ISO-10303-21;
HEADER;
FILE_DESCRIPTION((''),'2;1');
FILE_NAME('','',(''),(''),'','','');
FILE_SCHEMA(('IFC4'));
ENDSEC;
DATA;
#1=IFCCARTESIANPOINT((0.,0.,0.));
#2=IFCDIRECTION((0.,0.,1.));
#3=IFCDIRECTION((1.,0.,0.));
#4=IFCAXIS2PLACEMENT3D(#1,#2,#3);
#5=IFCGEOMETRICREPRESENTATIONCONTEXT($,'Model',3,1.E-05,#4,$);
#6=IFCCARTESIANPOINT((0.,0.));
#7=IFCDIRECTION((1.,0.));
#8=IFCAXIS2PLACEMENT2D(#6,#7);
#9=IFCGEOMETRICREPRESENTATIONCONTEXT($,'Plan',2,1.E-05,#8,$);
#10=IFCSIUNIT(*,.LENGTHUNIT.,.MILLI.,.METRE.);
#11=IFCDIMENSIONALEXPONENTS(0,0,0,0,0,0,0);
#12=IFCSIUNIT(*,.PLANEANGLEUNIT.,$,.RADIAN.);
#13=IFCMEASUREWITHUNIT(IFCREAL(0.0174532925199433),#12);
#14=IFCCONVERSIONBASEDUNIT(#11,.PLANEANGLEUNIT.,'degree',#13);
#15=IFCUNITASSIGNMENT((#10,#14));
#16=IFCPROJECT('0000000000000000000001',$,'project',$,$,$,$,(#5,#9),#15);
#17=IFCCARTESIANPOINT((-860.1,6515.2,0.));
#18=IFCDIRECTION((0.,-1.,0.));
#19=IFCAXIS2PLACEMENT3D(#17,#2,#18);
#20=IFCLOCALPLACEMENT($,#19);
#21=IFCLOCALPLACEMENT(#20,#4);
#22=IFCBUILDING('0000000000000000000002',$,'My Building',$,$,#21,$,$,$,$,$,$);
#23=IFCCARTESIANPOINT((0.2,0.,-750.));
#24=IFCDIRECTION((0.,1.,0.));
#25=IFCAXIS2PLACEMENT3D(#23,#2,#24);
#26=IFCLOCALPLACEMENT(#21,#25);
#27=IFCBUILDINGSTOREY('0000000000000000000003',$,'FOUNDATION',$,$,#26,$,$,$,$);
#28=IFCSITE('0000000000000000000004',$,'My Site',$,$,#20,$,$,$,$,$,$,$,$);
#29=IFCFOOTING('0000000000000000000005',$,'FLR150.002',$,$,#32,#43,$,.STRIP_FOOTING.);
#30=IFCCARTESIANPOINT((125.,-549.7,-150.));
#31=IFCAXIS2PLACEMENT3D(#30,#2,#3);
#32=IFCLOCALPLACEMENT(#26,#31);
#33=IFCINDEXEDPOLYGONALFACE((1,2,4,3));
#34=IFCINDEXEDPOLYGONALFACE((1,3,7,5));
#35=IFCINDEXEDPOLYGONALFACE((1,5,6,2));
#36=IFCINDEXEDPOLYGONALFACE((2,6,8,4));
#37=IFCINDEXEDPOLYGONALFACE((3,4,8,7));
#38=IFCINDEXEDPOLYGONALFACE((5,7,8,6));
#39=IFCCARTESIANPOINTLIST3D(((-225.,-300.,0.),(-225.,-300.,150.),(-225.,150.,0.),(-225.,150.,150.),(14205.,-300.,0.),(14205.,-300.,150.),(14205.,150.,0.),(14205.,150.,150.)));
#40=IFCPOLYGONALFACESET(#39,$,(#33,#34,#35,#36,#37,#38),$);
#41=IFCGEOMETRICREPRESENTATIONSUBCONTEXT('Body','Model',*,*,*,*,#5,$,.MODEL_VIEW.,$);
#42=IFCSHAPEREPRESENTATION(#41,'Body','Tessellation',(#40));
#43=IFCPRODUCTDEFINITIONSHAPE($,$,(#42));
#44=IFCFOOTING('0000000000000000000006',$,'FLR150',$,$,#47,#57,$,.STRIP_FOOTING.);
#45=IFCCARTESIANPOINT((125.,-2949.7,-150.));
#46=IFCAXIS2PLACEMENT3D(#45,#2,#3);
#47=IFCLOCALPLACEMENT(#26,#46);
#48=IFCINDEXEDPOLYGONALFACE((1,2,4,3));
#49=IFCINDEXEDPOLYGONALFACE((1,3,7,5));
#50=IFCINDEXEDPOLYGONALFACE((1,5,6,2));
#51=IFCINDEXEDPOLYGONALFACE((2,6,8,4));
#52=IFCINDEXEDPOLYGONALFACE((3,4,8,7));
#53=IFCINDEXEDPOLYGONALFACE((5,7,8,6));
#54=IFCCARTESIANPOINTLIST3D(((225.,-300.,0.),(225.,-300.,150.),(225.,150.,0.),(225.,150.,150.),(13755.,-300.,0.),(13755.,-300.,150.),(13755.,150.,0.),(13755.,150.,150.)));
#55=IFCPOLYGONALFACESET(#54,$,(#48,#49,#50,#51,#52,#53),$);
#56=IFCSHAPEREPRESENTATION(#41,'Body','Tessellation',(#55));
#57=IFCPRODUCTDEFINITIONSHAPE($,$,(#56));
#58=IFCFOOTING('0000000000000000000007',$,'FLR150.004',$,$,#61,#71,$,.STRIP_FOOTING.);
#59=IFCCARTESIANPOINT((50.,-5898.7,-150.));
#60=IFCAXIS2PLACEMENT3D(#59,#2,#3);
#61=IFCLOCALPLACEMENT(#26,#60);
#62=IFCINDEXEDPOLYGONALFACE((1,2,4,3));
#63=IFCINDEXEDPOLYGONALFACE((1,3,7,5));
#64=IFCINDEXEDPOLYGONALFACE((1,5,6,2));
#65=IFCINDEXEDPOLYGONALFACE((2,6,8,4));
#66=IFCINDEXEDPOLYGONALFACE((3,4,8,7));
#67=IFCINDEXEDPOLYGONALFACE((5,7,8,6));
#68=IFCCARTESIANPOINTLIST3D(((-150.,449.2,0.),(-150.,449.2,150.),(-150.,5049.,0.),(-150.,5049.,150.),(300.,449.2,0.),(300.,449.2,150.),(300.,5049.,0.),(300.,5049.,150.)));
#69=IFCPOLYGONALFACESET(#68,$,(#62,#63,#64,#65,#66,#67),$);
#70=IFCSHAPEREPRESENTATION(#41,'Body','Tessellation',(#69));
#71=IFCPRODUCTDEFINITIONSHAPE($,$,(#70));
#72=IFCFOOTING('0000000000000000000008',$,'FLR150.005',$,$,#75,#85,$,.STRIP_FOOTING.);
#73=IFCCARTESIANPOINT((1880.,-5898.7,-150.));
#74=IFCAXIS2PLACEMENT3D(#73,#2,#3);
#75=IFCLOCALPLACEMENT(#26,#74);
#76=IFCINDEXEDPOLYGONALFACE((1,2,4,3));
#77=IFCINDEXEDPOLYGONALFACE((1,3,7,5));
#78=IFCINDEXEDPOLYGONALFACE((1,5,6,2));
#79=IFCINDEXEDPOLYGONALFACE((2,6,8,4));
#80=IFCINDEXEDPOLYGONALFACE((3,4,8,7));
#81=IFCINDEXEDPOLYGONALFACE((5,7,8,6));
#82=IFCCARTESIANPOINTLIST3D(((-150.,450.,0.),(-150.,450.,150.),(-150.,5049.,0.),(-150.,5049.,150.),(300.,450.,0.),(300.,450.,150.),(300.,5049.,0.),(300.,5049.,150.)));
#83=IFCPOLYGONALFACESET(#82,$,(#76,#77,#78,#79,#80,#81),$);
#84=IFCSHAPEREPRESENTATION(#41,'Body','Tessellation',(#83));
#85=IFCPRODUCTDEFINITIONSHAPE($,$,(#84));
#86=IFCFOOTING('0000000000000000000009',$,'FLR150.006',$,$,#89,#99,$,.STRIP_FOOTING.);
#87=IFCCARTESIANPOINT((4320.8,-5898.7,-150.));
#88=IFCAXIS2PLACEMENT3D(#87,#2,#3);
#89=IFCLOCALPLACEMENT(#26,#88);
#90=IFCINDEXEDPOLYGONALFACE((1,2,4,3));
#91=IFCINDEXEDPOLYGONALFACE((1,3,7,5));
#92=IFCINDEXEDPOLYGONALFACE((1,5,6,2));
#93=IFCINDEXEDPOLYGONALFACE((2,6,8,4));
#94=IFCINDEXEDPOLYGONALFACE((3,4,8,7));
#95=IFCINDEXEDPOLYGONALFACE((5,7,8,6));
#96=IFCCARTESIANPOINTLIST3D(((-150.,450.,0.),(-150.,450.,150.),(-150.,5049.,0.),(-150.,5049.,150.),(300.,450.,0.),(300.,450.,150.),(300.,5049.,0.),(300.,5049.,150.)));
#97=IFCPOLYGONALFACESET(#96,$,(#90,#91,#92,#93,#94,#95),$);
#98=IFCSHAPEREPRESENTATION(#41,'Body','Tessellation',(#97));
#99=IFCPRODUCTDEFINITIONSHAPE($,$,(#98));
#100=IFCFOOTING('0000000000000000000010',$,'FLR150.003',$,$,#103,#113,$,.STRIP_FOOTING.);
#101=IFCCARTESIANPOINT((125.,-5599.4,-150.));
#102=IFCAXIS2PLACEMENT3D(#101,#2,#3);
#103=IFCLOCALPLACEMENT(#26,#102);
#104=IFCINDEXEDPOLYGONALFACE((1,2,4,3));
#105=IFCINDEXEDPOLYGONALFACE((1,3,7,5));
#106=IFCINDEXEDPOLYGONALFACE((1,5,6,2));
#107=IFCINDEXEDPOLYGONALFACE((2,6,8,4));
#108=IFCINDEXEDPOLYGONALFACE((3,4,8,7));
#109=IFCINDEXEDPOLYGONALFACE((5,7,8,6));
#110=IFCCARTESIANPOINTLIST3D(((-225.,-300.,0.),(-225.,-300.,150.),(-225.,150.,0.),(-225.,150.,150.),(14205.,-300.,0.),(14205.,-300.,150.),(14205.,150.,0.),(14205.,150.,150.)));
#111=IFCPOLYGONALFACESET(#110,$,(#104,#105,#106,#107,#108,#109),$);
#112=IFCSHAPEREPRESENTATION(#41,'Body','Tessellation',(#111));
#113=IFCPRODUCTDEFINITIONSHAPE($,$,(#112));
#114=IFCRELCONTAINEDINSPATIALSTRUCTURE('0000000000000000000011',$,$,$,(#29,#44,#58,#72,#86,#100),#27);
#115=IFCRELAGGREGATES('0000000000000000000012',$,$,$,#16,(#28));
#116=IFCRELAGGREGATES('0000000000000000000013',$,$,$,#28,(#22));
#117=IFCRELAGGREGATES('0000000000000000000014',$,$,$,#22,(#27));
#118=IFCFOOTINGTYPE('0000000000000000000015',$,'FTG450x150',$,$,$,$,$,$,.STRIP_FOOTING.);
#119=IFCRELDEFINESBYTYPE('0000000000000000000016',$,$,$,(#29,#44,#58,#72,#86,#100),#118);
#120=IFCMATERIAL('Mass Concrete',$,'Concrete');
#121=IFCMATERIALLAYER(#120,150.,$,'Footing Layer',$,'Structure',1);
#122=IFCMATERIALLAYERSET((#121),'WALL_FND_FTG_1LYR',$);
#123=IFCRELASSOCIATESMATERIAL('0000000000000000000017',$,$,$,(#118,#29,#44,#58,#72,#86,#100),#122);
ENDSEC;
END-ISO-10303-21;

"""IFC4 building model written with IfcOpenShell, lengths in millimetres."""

from ifc_helpers import new_model, entity, si_unit, converted_unit, frame, origin_with_axes, origin_2d_with_axis, place, context, subcontext, project, spatial, line, indexed_curve, outline, extrude, material, layer, layer_set, layer_usage, type_object, element, save


model = new_model("IFC4")

# Units and contexts
model_context = context("Model", 3, precision=1e-05, world=origin_with_axes())
plan_context = context("Plan", 2, precision=1e-05, world=origin_2d_with_axis())
body_context = subcontext(model_context, "Body", "Model", "MODEL_VIEW")
ifc_project = project(units=[si_unit("LENGTHUNIT", "METRE", prefix="MILLI"), converted_unit("PLANEANGLEUNIT", "degree", entity("IfcReal", 0.0174532925199433), si_unit("PLANEANGLEUNIT", "RADIAN"), dimensions=[0, 0, 0, 0, 0, 0, 0])], contexts=[model_context, plan_context])

# Site, building, storey
site_placement = place(None, frame((-860.1, 6515.2, 0.0), z_axis=(0.0, 0.0, 1.0), x_axis=(0.0, -1.0, 0.0)))
site = spatial("IfcSite", under=ifc_project, at=site_placement, Name="My Site")
building_placement = place(site_placement, frame((0.0, 0.0, 0.0), z_axis=(0.0, 0.0, 1.0), x_axis=(1.0, 0.0, 0.0)))
building = spatial("IfcBuilding", under=site, at=building_placement, Name="My Building")
storey_placement = place(building_placement, frame((0.2, 0.0, -750.0), z_axis=(0.0, 0.0, 1.0), x_axis=(0.0, 1.0, 0.0)))
storey = spatial("IfcBuildingStorey", under=building, at=storey_placement, Name="FOUNDATION")

# Footings
ifc_material_1 = material(Name="Mass Concrete", Category="Concrete")
ifc_layer_1 = layer(ifc_material_1, 150.0, Name="Footing Layer", Category="Structure", Priority=1)
ifc_layer_set_1 = layer_set([ifc_layer_1], Name="WALL_FND_FTG_1LYR")
ifc_layer_usage_1 = layer_usage(ifc_layer_set_1, "AXIS3", "POSITIVE", 0.0)
footing_type = type_object("IfcFootingType", Name="FTG450x150", PredefinedType="STRIP_FOOTING", material=ifc_layer_set_1)
footing_1_placement = place(storey_placement, frame((125.0, -549.7, -150.0), z_axis=(0.0, 0.0, 1.0), x_axis=(1.0, 0.0, 0.0)))
element("IfcFooting", 1, at=footing_1_placement, inside=storey, type_object=footing_type, material=ifc_layer_usage_1, Name="FLR150.002", PredefinedType="STRIP_FOOTING", context=body_context, shape_type="SweptSolid", body=[
    extrude(outline(indexed_curve([(14205.0, 150.0), (14205.0, -300.0), (-225.0, -300.0), (-225.0, 150.0)], segments=[line(3, 2), line(2, 1), line(1, 4), line(4, 3)], self_intersect=False)), None, (0.0, 0.0, 1.0), 150.0),
])
ifc_layer_usage_2 = layer_usage(ifc_layer_set_1, "AXIS3", "POSITIVE", 0.0)
footing_2_placement = place(storey_placement, frame((125.0, -2949.7, -150.0), z_axis=(0.0, 0.0, 1.0), x_axis=(1.0, 0.0, 0.0)))
element("IfcFooting", 2, at=footing_2_placement, inside=storey, type_object=footing_type, material=ifc_layer_usage_2, Name="FLR150", PredefinedType="STRIP_FOOTING", context=body_context, shape_type="SweptSolid", body=[
    extrude(outline(indexed_curve([(13755.0, 150.0), (13755.0, -300.0), (225.0, -300.0), (225.0, 150.0)], segments=[line(3, 2), line(2, 1), line(1, 4), line(4, 3)], self_intersect=False)), None, (0.0, 0.0, 1.0), 150.0),
])
ifc_layer_usage_3 = layer_usage(ifc_layer_set_1, "AXIS3", "POSITIVE", 0.0)
footing_3_placement = place(storey_placement, frame((50.0, -5898.7, -150.0), z_axis=(0.0, 0.0, 1.0), x_axis=(1.0, 0.0, 0.0)))
element("IfcFooting", 3, at=footing_3_placement, inside=storey, type_object=footing_type, material=ifc_layer_usage_3, Name="FLR150.004", PredefinedType="STRIP_FOOTING", context=body_context, shape_type="SweptSolid", body=[
    extrude(outline(indexed_curve([(300.0, 5049.0), (300.0, 449.2), (-150.0, 449.2), (-150.0, 5049.0)], segments=[line(3, 2), line(2, 1), line(1, 4), line(4, 3)], self_intersect=False)), None, (0.0, 0.0, 1.0), 150.0),
])
ifc_layer_usage_4 = layer_usage(ifc_layer_set_1, "AXIS3", "POSITIVE", 0.0)
footing_4_placement = place(storey_placement, frame((1880.0, -5898.7, -150.0), z_axis=(0.0, 0.0, 1.0), x_axis=(1.0, 0.0, 0.0)))
element("IfcFooting", 4, at=footing_4_placement, inside=storey, type_object=footing_type, material=ifc_layer_usage_4, Name="FLR150.005", PredefinedType="STRIP_FOOTING", context=body_context, shape_type="SweptSolid", body=[
    extrude(outline(indexed_curve([(300.0, 5049.0), (300.0, 450.0), (-150.0, 450.0), (-150.0, 5049.0)], segments=[line(3, 2), line(2, 1), line(1, 4), line(4, 3)], self_intersect=False)), None, (0.0, 0.0, 1.0), 150.0),
])
ifc_layer_usage_5 = layer_usage(ifc_layer_set_1, "AXIS3", "POSITIVE", 0.0)
footing_5_placement = place(storey_placement, frame((4320.8, -5898.7, -150.0), z_axis=(0.0, 0.0, 1.0), x_axis=(1.0, 0.0, 0.0)))
element("IfcFooting", 5, at=footing_5_placement, inside=storey, type_object=footing_type, material=ifc_layer_usage_5, Name="FLR150.006", PredefinedType="STRIP_FOOTING", context=body_context, shape_type="SweptSolid", body=[
    extrude(outline(indexed_curve([(-150.0, 450.0), (300.0, 450.0), (300.0, 5049.0), (-150.0, 5049.0)], segments=[line(3, 2), line(2, 1), line(1, 4), line(4, 3)], self_intersect=False)), None, (0.0, 0.0, 1.0), 150.0),
])
ifc_layer_usage_6 = layer_usage(ifc_layer_set_1, "AXIS3", "POSITIVE", 0.0)
footing_6_placement = place(storey_placement, frame((125.0, -5599.4, -150.0), z_axis=(0.0, 0.0, 1.0), x_axis=(1.0, 0.0, 0.0)))
element("IfcFooting", 6, at=footing_6_placement, inside=storey, type_object=footing_type, material=ifc_layer_usage_6, Name="FLR150.003", PredefinedType="STRIP_FOOTING", context=body_context, shape_type="SweptSolid", body=[
    extrude(outline(indexed_curve([(-225.0, -300.0), (14205.0, -300.0), (14205.0, 150.0), (-225.0, 150.0)], segments=[line(3, 2), line(2, 1), line(1, 4), line(4, 3)], self_intersect=False)), None, (0.0, 0.0, 1.0), 150.0),
])

save(model, "model.ifc")
